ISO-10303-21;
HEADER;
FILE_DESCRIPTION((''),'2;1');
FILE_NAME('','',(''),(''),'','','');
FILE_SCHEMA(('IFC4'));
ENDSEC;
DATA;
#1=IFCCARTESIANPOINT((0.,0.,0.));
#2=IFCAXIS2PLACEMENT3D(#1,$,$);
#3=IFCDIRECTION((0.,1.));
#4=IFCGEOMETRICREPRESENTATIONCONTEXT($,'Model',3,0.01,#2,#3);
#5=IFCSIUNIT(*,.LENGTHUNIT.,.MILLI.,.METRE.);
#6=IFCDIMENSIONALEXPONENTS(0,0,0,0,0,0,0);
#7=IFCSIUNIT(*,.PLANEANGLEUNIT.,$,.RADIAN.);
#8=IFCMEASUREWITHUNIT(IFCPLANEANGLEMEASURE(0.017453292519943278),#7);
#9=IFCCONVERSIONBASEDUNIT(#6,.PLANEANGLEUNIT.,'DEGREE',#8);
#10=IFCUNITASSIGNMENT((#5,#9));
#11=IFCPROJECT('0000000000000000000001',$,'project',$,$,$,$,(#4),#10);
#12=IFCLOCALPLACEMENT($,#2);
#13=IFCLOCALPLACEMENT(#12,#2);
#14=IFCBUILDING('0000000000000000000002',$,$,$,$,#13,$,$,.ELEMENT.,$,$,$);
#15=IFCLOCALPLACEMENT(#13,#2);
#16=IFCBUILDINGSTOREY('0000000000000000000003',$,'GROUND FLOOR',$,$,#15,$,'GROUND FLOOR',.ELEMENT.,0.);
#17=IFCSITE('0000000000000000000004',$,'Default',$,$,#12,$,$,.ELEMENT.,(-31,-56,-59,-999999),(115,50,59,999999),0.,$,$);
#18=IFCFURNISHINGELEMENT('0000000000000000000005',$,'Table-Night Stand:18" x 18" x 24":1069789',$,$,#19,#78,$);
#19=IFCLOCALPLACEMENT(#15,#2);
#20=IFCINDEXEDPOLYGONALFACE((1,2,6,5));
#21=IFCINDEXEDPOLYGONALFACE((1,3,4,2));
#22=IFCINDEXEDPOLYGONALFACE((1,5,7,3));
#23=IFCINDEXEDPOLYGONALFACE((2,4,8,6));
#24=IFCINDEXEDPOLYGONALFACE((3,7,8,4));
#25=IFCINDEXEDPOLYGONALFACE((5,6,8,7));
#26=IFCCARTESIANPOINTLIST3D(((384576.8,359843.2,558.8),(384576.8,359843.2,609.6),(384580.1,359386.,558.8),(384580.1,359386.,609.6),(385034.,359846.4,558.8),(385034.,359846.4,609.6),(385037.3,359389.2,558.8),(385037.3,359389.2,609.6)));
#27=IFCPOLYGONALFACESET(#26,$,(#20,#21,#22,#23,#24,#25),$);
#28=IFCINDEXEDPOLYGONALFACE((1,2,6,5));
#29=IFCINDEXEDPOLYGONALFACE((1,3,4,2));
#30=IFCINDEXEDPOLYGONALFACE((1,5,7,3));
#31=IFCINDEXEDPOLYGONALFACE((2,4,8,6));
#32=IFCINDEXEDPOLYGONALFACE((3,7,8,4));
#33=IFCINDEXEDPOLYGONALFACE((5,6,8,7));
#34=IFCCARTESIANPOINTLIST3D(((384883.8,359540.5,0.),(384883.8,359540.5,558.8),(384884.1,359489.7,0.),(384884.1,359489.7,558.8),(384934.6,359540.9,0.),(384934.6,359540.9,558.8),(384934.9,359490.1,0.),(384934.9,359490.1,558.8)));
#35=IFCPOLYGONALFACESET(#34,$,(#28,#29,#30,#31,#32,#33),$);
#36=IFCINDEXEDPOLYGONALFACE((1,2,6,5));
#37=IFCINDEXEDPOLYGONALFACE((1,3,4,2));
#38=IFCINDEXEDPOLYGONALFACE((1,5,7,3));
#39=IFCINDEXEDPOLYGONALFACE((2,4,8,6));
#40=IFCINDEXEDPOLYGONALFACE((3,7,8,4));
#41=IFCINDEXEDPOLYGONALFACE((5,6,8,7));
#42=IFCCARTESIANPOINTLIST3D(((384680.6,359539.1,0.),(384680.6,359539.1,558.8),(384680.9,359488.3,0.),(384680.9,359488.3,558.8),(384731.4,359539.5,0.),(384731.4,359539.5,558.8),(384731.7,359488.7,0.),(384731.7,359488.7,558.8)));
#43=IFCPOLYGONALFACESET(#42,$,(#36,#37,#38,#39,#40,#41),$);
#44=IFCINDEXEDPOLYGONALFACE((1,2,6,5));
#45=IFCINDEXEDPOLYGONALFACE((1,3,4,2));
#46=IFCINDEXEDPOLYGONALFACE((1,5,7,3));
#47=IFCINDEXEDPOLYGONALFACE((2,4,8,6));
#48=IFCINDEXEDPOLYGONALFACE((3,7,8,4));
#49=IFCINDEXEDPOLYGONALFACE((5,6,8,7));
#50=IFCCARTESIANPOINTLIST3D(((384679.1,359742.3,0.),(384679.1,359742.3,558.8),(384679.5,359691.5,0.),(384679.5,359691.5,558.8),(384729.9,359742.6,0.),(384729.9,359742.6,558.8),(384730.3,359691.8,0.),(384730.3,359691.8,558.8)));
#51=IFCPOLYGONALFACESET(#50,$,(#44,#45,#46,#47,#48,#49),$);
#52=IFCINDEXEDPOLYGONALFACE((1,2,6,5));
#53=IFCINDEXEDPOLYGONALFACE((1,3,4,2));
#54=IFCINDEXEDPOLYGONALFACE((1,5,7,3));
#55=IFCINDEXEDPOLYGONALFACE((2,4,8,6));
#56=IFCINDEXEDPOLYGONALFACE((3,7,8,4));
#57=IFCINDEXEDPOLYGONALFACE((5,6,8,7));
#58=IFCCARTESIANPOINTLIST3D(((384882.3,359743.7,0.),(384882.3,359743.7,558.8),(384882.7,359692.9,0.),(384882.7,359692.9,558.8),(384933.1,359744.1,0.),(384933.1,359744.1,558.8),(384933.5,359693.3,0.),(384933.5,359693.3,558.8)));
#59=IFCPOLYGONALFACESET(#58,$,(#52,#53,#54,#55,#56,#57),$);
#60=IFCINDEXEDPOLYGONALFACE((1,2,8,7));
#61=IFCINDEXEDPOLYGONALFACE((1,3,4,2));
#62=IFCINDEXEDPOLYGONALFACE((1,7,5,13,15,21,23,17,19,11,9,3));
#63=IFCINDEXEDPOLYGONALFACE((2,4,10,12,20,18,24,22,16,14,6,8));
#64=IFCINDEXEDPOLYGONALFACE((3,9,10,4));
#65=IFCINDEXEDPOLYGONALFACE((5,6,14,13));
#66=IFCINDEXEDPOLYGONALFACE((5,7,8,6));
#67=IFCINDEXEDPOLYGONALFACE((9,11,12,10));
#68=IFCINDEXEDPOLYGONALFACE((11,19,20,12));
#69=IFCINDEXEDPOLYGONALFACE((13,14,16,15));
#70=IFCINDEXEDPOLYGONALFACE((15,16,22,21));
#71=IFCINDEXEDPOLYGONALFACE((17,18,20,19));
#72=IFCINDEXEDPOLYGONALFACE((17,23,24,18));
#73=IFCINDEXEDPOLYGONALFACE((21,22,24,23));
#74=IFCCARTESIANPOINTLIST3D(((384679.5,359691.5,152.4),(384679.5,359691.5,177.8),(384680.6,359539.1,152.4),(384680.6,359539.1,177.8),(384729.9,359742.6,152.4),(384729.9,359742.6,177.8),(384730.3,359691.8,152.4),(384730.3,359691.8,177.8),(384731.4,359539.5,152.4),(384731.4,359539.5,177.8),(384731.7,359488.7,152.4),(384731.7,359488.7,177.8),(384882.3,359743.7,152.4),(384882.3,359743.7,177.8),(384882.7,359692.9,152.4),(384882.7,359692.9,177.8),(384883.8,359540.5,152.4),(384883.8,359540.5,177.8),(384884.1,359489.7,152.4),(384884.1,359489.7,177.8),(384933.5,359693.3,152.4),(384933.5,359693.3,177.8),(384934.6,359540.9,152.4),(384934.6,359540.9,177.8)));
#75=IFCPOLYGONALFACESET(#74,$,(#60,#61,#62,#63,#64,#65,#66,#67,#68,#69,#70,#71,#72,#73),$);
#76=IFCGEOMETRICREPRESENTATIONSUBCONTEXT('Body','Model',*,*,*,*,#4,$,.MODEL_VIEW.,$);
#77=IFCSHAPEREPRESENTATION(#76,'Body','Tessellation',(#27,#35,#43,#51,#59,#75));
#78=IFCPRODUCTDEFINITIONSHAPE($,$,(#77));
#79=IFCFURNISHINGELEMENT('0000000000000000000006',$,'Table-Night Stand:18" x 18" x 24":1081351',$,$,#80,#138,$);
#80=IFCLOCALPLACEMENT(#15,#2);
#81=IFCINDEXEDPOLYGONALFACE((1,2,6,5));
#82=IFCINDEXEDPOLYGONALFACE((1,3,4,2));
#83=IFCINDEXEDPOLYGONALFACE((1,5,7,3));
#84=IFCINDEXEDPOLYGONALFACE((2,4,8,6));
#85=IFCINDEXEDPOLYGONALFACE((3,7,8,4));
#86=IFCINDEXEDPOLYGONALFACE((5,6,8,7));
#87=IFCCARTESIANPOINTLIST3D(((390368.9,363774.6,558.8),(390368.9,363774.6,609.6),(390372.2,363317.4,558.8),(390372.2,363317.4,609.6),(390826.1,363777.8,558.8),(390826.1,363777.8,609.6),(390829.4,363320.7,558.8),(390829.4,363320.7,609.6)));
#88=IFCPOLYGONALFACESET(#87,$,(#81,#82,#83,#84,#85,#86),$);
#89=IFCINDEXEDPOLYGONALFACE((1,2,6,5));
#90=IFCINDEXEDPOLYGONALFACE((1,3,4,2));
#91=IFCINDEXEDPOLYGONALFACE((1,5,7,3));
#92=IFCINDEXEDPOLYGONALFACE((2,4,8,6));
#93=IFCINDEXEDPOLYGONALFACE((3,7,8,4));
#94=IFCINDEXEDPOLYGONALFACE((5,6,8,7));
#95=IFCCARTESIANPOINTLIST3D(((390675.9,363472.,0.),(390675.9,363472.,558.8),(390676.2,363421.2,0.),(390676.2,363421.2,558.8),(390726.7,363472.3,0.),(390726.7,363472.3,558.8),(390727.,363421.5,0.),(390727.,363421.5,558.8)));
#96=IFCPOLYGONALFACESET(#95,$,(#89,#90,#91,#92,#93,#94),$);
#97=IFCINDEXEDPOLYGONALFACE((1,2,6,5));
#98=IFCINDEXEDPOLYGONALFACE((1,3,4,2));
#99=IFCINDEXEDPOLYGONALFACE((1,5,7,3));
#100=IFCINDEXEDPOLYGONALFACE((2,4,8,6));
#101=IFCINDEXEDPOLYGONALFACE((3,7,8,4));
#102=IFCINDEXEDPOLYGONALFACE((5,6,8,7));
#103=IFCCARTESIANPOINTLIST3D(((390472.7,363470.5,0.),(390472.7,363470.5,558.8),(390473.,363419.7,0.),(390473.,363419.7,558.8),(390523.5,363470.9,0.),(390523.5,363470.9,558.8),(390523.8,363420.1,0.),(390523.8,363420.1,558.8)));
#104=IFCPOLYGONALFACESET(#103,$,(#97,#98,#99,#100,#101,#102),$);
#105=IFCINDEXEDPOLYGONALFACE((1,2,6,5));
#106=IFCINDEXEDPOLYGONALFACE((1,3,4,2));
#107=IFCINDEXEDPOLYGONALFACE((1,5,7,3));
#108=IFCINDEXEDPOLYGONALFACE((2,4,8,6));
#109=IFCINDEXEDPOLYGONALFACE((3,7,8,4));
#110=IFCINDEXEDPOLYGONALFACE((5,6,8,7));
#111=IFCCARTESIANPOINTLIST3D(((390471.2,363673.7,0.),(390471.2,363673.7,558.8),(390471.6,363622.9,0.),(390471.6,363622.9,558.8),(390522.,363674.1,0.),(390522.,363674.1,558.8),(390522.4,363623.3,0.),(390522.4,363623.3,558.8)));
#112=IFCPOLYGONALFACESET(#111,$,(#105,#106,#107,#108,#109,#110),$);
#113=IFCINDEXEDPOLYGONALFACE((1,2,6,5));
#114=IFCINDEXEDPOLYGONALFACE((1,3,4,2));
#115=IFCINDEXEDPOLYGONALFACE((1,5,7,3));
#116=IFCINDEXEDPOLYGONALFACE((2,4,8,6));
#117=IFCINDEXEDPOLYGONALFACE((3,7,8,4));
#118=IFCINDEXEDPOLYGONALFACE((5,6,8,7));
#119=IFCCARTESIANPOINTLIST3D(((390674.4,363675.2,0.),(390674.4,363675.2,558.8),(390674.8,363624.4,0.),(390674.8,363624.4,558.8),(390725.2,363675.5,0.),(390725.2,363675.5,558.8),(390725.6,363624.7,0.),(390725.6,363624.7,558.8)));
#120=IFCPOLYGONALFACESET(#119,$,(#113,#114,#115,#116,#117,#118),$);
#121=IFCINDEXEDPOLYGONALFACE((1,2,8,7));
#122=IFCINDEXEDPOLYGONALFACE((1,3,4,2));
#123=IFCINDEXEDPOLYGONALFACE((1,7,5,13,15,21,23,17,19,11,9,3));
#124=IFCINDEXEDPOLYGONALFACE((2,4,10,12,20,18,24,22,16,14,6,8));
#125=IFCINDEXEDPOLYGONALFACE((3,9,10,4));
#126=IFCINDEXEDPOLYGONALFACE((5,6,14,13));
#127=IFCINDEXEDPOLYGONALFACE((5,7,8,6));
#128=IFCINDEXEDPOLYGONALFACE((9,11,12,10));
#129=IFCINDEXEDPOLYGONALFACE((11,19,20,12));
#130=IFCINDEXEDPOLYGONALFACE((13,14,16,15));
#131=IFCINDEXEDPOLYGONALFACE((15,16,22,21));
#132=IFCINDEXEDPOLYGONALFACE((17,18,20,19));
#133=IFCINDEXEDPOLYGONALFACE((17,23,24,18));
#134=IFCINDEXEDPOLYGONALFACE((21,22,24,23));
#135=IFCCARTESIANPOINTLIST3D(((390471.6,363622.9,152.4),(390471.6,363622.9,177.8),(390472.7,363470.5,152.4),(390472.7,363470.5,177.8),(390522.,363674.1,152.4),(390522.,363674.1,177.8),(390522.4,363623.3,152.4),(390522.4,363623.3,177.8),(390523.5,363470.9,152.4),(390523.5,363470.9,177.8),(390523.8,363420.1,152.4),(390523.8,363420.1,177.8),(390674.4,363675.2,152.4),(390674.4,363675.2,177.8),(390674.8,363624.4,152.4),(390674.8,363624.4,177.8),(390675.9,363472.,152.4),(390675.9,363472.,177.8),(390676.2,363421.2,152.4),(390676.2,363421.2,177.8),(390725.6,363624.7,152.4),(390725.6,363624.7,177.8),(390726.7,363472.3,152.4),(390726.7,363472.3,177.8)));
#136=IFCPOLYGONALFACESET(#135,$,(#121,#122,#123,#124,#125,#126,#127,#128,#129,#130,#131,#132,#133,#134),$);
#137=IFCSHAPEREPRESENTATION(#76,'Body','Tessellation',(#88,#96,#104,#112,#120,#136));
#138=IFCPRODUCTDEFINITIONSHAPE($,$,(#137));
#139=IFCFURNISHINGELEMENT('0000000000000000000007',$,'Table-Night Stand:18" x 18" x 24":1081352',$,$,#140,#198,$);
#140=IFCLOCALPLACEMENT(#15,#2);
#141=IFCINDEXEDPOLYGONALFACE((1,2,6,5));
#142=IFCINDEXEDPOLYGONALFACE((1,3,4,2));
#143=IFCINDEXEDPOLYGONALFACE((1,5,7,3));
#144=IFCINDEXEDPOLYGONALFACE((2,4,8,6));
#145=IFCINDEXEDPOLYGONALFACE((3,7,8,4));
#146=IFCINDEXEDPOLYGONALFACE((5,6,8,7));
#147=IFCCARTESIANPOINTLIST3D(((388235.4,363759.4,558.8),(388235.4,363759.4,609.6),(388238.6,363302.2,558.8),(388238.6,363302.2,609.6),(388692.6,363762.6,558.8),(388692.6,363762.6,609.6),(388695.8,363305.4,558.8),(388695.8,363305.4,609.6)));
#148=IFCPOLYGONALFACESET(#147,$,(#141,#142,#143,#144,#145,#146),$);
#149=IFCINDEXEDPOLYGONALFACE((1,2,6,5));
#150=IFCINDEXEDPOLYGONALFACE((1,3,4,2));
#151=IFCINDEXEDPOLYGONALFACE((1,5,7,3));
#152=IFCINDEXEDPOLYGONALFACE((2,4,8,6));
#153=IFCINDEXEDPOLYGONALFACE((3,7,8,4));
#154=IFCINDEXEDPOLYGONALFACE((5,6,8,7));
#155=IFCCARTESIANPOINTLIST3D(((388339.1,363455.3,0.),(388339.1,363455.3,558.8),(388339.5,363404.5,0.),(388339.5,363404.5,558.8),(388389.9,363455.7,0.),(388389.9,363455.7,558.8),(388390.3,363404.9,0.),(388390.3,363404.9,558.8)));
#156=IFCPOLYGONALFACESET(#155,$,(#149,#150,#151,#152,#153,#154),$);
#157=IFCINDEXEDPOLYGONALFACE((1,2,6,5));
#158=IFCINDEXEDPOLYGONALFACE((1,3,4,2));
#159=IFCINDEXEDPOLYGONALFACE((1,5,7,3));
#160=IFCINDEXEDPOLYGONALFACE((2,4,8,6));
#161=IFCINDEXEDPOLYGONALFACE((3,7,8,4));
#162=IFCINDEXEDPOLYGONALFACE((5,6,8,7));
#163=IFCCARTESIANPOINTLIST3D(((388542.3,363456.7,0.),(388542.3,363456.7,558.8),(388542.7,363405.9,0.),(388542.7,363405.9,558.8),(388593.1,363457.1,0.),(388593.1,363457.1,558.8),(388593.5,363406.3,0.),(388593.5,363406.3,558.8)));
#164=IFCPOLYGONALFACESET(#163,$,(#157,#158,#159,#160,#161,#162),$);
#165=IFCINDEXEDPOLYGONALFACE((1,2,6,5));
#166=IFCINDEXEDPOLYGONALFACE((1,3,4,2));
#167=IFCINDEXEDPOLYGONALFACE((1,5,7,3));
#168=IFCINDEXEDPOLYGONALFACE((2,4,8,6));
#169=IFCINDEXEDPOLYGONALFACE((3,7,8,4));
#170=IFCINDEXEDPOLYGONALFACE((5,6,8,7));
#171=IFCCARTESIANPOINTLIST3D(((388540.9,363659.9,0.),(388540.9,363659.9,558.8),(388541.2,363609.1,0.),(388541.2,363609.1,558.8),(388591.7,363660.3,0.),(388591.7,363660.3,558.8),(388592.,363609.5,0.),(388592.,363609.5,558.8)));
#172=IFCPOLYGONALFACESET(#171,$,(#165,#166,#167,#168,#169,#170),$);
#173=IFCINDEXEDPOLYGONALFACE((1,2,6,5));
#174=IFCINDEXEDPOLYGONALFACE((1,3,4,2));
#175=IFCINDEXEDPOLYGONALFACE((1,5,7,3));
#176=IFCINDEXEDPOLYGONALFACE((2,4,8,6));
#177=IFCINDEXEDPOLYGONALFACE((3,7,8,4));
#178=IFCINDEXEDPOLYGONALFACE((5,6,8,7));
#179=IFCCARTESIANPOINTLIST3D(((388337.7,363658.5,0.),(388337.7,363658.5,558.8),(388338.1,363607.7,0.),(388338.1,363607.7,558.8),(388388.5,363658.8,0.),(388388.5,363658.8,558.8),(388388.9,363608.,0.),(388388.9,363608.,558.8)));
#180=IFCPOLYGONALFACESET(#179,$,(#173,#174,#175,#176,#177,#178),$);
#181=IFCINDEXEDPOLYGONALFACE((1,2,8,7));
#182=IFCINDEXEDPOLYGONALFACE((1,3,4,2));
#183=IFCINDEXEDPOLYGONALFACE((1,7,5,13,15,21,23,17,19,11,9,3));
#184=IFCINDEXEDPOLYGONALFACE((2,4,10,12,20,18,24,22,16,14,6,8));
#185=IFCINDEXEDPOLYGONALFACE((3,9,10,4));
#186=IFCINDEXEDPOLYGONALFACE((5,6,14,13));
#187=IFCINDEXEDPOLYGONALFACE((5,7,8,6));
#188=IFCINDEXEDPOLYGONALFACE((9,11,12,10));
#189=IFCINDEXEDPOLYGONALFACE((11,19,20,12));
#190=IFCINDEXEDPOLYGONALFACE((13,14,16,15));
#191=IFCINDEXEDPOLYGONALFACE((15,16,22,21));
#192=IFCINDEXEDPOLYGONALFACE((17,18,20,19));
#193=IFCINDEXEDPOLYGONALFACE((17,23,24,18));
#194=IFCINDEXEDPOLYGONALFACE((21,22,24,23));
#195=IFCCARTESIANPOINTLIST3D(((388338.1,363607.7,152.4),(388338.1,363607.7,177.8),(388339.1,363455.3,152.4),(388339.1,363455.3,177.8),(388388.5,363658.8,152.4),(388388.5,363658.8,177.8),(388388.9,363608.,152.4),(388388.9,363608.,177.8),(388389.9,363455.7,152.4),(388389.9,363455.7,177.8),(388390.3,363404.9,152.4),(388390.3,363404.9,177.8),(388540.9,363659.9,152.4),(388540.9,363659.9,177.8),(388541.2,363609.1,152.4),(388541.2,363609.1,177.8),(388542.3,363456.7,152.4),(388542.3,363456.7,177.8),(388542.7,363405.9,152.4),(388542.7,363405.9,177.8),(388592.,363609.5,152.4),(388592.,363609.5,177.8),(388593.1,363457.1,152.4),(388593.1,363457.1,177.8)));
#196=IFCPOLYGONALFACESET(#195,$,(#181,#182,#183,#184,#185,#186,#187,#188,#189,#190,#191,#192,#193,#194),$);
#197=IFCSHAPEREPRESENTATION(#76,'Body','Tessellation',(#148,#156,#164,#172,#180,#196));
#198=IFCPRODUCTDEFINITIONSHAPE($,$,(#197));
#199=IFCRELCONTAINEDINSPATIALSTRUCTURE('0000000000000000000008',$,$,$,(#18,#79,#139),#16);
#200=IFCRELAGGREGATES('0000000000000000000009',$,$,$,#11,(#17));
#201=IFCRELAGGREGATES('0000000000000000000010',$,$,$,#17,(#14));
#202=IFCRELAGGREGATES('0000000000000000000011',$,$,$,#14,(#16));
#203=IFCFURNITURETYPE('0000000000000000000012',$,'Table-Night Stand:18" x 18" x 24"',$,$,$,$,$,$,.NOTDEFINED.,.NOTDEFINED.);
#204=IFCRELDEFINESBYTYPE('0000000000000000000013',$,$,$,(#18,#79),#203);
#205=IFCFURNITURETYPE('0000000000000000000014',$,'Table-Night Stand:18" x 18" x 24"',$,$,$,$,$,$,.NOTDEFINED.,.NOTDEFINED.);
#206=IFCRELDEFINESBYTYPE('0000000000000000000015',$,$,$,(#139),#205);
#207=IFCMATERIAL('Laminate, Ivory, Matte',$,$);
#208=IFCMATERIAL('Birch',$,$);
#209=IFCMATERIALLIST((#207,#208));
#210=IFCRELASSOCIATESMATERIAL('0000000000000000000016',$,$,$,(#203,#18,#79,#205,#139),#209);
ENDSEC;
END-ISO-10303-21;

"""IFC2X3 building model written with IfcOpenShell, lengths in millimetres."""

from ifc_helpers import new_model, entity, si_unit, converted_unit, direction, frame, frame_2d, origin, origin_2d_with_axis, place, context, subcontext, project, spatial, polyline, rectangle, outline, extrude, source, transform, mapped, material, material_list, type_object, type_shapes, element, save


model = new_model("IFC2X3")

# Units and contexts
model_context = context("Model", 3, precision=0.01, world=origin(), true_north=direction((0.0, 1.0)))
body_context = subcontext(model_context, "Body", "Model", "MODEL_VIEW")
ifc_project = project(units=[si_unit("LENGTHUNIT", "METRE", prefix="MILLI"), converted_unit("PLANEANGLEUNIT", "DEGREE", entity("IfcPlaneAngleMeasure", 0.017453292519943278), si_unit("PLANEANGLEUNIT", "RADIAN"), dimensions=[0, 0, 0, 0, 0, 0, 0])], contexts=[model_context])

# Site, building, storey
site_placement = place(None, origin())
site = spatial("IfcSite", under=ifc_project, at=site_placement, Name="Default", CompositionType="ELEMENT", RefLatitude=(-31, -56, -59, -999999), RefLongitude=(115, 50, 59, 999999), RefElevation=0.0)
building_placement = place(site_placement, origin())
building = spatial("IfcBuilding", under=site, at=building_placement, CompositionType="ELEMENT")
storey_placement = place(building_placement, origin())
storey = spatial("IfcBuildingStorey", under=building, at=storey_placement, Name="GROUND FLOOR", LongName="GROUND FLOOR", CompositionType="ELEMENT", Elevation=0.0)

# Furnishing elements
ifc_material_1 = material(Name="Laminate, Ivory, Matte")
ifc_material_2 = material(Name="Birch")
ifc_material_list_1 = material_list([ifc_material_1, ifc_material_2])
furniture_type_1 = type_object("IfcFurnitureType", Name="Table-Night Stand:18\" x 18\" x 24\"", AssemblyPlace="NOTDEFINED", material=ifc_material_list_1)
shared_shape_1 = source(origin(), body_context, "Body", "SweptSolid", [
    extrude(rectangle(XDim=457.2, YDim=457.2, at=origin_2d_with_axis()), frame((232.3, -228.6, 558.8), z_axis=(0.0, 0.0, 1.0), x_axis=(-1.0, 0.0, 0.0)), (0.0, 0.0, 1.0), 50.8),
    extrude(rectangle(XDim=50.8, YDim=50.8, at=origin_2d_with_axis()), frame((333.9, -330.2, 0.0), z_axis=(0.0, 0.0, 1.0), x_axis=(0.0, 1.0, 0.0)), (0.0, 0.0, 1.0), 558.8),
    extrude(rectangle(XDim=50.8, YDim=50.8, at=frame_2d((0.0, 0.0), x_axis=(1.0, 0.0))), frame((130.7, -330.2, 0.0), z_axis=(0.0, 0.0, 1.0), x_axis=(0.0, 1.0, 0.0)), (0.0, 0.0, 1.0), 558.8),
    extrude(rectangle(XDim=50.8, YDim=50.8, at=frame_2d((0.0, 0.0), x_axis=(1.0, 0.0))), frame((130.7, -127.0, 0.0), z_axis=(0.0, 0.0, 1.0), x_axis=(0.0, 1.0, 0.0)), (0.0, 0.0, 1.0), 558.8),
    extrude(rectangle(XDim=50.8, YDim=50.8, at=frame_2d((0.0, 0.0), x_axis=(1.0, 0.0))), frame((333.9, -127.0, 0.0), z_axis=(0.0, 0.0, 1.0), x_axis=(0.0, 1.0, 0.0)), (0.0, 0.0, 1.0), 558.8),
    extrude(outline(polyline([(-76.2, -127.0), (76.2, -127.0), (76.2, -76.2), (127.0, -76.2), (127.0, 76.2), (76.2, 76.2), (76.2, 127.0), (-76.2, 127.0), (-76.2, 76.2), (-127.0, 76.2), (-127.0, -76.2), (-76.2, -76.2), (-76.2, -127.0)])), frame((232.3, -228.6, 152.4)), (0.0, 0.0, 1.0), 25.4),
])
type_shapes(furniture_type_1, [shared_shape_1])
for number, where, z_axis, x_axis, name in (
    (1, (384573.1, 359843.1, 0.0), (0.0, 0.0, 1.0), (0.999975, 0.007134, 0.0), "Table-Night Stand:18\" x 18\" x 24\":1069789"),
    (2, (390365.2, 363774.6, 0.0), (0.0, 0.0, 1.0), (0.999975, 0.007134, 0.0), "Table-Night Stand:18\" x 18\" x 24\":1081351"),
):
    element("IfcFurnishingElement", number, at=place(storey_placement, frame(where, z_axis=z_axis, x_axis=x_axis)), inside=storey, type_object=furniture_type_1, material=ifc_material_list_1, Name=name, context=body_context, shape_type="MappedRepresentation", body=[
        mapped(shared_shape_1, transform((0.0, 0.0, 0.0), scale=1.0)),
    ])
furniture_type_2 = type_object("IfcFurnitureType", Name="Table-Night Stand:18\" x 18\" x 24\"", AssemblyPlace="NOTDEFINED", material=ifc_material_list_1)
shared_shape_2 = source(origin(), body_context, "Body", "SweptSolid", [
    extrude(rectangle(XDim=457.2, YDim=457.2, at=origin_2d_with_axis()), frame((232.3, 228.6, 558.8), z_axis=(0.0, 0.0, 1.0), x_axis=(0.0, 1.0, 0.0)), (0.0, 0.0, 1.0), 50.8),
    extrude(rectangle(XDim=50.8, YDim=50.8, at=origin_2d_with_axis()), frame((333.9, 330.2, 0.0), z_axis=(0.0, 0.0, 1.0), x_axis=(-1.0, 0.0, 0.0)), (0.0, 0.0, 1.0), 558.8),
    extrude(rectangle(XDim=50.8, YDim=50.8, at=frame_2d((0.0, 0.0), x_axis=(1.0, 0.0))), frame((130.7, 330.2, 0.0), z_axis=(0.0, 0.0, 1.0), x_axis=(-1.0, 0.0, 0.0)), (0.0, 0.0, 1.0), 558.8),
    extrude(rectangle(XDim=50.8, YDim=50.8, at=frame_2d((0.0, 0.0), x_axis=(1.0, 0.0))), frame((130.7, 127.0, 0.0), z_axis=(0.0, 0.0, 1.0), x_axis=(-1.0, 0.0, 0.0)), (0.0, 0.0, 1.0), 558.8),
    extrude(rectangle(XDim=50.8, YDim=50.8, at=frame_2d((0.0, 0.0), x_axis=(1.0, 0.0))), frame((333.9, 127.0, 0.0), z_axis=(0.0, 0.0, 1.0), x_axis=(-1.0, 0.0, 0.0)), (0.0, 0.0, 1.0), 558.8),
    extrude(outline(polyline([(-127.0, 76.2), (-127.0, -76.2), (-76.2, -76.2), (-76.2, -127.0), (76.2, -127.0), (76.2, -76.2), (127.0, -76.2), (127.0, 76.2), (76.2, 76.2), (76.2, 127.0), (-76.2, 127.0), (-76.2, 76.2), (-127.0, 76.2)])), frame((232.3, 228.6, 152.4), z_axis=(0.0, 0.0, -1.0), x_axis=(0.0, -1.0, 0.0)), (0.0, 0.0, -1.0), 25.4),
])
type_shapes(furniture_type_2, [shared_shape_2])
furnishing_1_placement = place(storey_placement, frame((388696.3, 363762.6, 0.0), z_axis=(0.0, 0.0, 1.0), x_axis=(-0.999975, -0.007134, 0.0)))
element("IfcFurnishingElement", 3, at=furnishing_1_placement, inside=storey, type_object=furniture_type_2, material=ifc_material_list_1, Name="Table-Night Stand:18\" x 18\" x 24\":1081352", context=body_context, shape_type="MappedRepresentation", body=[
    mapped(shared_shape_2, transform((0.0, 0.0, 0.0), scale=1.0)),
])

save(model, "model.ifc")
